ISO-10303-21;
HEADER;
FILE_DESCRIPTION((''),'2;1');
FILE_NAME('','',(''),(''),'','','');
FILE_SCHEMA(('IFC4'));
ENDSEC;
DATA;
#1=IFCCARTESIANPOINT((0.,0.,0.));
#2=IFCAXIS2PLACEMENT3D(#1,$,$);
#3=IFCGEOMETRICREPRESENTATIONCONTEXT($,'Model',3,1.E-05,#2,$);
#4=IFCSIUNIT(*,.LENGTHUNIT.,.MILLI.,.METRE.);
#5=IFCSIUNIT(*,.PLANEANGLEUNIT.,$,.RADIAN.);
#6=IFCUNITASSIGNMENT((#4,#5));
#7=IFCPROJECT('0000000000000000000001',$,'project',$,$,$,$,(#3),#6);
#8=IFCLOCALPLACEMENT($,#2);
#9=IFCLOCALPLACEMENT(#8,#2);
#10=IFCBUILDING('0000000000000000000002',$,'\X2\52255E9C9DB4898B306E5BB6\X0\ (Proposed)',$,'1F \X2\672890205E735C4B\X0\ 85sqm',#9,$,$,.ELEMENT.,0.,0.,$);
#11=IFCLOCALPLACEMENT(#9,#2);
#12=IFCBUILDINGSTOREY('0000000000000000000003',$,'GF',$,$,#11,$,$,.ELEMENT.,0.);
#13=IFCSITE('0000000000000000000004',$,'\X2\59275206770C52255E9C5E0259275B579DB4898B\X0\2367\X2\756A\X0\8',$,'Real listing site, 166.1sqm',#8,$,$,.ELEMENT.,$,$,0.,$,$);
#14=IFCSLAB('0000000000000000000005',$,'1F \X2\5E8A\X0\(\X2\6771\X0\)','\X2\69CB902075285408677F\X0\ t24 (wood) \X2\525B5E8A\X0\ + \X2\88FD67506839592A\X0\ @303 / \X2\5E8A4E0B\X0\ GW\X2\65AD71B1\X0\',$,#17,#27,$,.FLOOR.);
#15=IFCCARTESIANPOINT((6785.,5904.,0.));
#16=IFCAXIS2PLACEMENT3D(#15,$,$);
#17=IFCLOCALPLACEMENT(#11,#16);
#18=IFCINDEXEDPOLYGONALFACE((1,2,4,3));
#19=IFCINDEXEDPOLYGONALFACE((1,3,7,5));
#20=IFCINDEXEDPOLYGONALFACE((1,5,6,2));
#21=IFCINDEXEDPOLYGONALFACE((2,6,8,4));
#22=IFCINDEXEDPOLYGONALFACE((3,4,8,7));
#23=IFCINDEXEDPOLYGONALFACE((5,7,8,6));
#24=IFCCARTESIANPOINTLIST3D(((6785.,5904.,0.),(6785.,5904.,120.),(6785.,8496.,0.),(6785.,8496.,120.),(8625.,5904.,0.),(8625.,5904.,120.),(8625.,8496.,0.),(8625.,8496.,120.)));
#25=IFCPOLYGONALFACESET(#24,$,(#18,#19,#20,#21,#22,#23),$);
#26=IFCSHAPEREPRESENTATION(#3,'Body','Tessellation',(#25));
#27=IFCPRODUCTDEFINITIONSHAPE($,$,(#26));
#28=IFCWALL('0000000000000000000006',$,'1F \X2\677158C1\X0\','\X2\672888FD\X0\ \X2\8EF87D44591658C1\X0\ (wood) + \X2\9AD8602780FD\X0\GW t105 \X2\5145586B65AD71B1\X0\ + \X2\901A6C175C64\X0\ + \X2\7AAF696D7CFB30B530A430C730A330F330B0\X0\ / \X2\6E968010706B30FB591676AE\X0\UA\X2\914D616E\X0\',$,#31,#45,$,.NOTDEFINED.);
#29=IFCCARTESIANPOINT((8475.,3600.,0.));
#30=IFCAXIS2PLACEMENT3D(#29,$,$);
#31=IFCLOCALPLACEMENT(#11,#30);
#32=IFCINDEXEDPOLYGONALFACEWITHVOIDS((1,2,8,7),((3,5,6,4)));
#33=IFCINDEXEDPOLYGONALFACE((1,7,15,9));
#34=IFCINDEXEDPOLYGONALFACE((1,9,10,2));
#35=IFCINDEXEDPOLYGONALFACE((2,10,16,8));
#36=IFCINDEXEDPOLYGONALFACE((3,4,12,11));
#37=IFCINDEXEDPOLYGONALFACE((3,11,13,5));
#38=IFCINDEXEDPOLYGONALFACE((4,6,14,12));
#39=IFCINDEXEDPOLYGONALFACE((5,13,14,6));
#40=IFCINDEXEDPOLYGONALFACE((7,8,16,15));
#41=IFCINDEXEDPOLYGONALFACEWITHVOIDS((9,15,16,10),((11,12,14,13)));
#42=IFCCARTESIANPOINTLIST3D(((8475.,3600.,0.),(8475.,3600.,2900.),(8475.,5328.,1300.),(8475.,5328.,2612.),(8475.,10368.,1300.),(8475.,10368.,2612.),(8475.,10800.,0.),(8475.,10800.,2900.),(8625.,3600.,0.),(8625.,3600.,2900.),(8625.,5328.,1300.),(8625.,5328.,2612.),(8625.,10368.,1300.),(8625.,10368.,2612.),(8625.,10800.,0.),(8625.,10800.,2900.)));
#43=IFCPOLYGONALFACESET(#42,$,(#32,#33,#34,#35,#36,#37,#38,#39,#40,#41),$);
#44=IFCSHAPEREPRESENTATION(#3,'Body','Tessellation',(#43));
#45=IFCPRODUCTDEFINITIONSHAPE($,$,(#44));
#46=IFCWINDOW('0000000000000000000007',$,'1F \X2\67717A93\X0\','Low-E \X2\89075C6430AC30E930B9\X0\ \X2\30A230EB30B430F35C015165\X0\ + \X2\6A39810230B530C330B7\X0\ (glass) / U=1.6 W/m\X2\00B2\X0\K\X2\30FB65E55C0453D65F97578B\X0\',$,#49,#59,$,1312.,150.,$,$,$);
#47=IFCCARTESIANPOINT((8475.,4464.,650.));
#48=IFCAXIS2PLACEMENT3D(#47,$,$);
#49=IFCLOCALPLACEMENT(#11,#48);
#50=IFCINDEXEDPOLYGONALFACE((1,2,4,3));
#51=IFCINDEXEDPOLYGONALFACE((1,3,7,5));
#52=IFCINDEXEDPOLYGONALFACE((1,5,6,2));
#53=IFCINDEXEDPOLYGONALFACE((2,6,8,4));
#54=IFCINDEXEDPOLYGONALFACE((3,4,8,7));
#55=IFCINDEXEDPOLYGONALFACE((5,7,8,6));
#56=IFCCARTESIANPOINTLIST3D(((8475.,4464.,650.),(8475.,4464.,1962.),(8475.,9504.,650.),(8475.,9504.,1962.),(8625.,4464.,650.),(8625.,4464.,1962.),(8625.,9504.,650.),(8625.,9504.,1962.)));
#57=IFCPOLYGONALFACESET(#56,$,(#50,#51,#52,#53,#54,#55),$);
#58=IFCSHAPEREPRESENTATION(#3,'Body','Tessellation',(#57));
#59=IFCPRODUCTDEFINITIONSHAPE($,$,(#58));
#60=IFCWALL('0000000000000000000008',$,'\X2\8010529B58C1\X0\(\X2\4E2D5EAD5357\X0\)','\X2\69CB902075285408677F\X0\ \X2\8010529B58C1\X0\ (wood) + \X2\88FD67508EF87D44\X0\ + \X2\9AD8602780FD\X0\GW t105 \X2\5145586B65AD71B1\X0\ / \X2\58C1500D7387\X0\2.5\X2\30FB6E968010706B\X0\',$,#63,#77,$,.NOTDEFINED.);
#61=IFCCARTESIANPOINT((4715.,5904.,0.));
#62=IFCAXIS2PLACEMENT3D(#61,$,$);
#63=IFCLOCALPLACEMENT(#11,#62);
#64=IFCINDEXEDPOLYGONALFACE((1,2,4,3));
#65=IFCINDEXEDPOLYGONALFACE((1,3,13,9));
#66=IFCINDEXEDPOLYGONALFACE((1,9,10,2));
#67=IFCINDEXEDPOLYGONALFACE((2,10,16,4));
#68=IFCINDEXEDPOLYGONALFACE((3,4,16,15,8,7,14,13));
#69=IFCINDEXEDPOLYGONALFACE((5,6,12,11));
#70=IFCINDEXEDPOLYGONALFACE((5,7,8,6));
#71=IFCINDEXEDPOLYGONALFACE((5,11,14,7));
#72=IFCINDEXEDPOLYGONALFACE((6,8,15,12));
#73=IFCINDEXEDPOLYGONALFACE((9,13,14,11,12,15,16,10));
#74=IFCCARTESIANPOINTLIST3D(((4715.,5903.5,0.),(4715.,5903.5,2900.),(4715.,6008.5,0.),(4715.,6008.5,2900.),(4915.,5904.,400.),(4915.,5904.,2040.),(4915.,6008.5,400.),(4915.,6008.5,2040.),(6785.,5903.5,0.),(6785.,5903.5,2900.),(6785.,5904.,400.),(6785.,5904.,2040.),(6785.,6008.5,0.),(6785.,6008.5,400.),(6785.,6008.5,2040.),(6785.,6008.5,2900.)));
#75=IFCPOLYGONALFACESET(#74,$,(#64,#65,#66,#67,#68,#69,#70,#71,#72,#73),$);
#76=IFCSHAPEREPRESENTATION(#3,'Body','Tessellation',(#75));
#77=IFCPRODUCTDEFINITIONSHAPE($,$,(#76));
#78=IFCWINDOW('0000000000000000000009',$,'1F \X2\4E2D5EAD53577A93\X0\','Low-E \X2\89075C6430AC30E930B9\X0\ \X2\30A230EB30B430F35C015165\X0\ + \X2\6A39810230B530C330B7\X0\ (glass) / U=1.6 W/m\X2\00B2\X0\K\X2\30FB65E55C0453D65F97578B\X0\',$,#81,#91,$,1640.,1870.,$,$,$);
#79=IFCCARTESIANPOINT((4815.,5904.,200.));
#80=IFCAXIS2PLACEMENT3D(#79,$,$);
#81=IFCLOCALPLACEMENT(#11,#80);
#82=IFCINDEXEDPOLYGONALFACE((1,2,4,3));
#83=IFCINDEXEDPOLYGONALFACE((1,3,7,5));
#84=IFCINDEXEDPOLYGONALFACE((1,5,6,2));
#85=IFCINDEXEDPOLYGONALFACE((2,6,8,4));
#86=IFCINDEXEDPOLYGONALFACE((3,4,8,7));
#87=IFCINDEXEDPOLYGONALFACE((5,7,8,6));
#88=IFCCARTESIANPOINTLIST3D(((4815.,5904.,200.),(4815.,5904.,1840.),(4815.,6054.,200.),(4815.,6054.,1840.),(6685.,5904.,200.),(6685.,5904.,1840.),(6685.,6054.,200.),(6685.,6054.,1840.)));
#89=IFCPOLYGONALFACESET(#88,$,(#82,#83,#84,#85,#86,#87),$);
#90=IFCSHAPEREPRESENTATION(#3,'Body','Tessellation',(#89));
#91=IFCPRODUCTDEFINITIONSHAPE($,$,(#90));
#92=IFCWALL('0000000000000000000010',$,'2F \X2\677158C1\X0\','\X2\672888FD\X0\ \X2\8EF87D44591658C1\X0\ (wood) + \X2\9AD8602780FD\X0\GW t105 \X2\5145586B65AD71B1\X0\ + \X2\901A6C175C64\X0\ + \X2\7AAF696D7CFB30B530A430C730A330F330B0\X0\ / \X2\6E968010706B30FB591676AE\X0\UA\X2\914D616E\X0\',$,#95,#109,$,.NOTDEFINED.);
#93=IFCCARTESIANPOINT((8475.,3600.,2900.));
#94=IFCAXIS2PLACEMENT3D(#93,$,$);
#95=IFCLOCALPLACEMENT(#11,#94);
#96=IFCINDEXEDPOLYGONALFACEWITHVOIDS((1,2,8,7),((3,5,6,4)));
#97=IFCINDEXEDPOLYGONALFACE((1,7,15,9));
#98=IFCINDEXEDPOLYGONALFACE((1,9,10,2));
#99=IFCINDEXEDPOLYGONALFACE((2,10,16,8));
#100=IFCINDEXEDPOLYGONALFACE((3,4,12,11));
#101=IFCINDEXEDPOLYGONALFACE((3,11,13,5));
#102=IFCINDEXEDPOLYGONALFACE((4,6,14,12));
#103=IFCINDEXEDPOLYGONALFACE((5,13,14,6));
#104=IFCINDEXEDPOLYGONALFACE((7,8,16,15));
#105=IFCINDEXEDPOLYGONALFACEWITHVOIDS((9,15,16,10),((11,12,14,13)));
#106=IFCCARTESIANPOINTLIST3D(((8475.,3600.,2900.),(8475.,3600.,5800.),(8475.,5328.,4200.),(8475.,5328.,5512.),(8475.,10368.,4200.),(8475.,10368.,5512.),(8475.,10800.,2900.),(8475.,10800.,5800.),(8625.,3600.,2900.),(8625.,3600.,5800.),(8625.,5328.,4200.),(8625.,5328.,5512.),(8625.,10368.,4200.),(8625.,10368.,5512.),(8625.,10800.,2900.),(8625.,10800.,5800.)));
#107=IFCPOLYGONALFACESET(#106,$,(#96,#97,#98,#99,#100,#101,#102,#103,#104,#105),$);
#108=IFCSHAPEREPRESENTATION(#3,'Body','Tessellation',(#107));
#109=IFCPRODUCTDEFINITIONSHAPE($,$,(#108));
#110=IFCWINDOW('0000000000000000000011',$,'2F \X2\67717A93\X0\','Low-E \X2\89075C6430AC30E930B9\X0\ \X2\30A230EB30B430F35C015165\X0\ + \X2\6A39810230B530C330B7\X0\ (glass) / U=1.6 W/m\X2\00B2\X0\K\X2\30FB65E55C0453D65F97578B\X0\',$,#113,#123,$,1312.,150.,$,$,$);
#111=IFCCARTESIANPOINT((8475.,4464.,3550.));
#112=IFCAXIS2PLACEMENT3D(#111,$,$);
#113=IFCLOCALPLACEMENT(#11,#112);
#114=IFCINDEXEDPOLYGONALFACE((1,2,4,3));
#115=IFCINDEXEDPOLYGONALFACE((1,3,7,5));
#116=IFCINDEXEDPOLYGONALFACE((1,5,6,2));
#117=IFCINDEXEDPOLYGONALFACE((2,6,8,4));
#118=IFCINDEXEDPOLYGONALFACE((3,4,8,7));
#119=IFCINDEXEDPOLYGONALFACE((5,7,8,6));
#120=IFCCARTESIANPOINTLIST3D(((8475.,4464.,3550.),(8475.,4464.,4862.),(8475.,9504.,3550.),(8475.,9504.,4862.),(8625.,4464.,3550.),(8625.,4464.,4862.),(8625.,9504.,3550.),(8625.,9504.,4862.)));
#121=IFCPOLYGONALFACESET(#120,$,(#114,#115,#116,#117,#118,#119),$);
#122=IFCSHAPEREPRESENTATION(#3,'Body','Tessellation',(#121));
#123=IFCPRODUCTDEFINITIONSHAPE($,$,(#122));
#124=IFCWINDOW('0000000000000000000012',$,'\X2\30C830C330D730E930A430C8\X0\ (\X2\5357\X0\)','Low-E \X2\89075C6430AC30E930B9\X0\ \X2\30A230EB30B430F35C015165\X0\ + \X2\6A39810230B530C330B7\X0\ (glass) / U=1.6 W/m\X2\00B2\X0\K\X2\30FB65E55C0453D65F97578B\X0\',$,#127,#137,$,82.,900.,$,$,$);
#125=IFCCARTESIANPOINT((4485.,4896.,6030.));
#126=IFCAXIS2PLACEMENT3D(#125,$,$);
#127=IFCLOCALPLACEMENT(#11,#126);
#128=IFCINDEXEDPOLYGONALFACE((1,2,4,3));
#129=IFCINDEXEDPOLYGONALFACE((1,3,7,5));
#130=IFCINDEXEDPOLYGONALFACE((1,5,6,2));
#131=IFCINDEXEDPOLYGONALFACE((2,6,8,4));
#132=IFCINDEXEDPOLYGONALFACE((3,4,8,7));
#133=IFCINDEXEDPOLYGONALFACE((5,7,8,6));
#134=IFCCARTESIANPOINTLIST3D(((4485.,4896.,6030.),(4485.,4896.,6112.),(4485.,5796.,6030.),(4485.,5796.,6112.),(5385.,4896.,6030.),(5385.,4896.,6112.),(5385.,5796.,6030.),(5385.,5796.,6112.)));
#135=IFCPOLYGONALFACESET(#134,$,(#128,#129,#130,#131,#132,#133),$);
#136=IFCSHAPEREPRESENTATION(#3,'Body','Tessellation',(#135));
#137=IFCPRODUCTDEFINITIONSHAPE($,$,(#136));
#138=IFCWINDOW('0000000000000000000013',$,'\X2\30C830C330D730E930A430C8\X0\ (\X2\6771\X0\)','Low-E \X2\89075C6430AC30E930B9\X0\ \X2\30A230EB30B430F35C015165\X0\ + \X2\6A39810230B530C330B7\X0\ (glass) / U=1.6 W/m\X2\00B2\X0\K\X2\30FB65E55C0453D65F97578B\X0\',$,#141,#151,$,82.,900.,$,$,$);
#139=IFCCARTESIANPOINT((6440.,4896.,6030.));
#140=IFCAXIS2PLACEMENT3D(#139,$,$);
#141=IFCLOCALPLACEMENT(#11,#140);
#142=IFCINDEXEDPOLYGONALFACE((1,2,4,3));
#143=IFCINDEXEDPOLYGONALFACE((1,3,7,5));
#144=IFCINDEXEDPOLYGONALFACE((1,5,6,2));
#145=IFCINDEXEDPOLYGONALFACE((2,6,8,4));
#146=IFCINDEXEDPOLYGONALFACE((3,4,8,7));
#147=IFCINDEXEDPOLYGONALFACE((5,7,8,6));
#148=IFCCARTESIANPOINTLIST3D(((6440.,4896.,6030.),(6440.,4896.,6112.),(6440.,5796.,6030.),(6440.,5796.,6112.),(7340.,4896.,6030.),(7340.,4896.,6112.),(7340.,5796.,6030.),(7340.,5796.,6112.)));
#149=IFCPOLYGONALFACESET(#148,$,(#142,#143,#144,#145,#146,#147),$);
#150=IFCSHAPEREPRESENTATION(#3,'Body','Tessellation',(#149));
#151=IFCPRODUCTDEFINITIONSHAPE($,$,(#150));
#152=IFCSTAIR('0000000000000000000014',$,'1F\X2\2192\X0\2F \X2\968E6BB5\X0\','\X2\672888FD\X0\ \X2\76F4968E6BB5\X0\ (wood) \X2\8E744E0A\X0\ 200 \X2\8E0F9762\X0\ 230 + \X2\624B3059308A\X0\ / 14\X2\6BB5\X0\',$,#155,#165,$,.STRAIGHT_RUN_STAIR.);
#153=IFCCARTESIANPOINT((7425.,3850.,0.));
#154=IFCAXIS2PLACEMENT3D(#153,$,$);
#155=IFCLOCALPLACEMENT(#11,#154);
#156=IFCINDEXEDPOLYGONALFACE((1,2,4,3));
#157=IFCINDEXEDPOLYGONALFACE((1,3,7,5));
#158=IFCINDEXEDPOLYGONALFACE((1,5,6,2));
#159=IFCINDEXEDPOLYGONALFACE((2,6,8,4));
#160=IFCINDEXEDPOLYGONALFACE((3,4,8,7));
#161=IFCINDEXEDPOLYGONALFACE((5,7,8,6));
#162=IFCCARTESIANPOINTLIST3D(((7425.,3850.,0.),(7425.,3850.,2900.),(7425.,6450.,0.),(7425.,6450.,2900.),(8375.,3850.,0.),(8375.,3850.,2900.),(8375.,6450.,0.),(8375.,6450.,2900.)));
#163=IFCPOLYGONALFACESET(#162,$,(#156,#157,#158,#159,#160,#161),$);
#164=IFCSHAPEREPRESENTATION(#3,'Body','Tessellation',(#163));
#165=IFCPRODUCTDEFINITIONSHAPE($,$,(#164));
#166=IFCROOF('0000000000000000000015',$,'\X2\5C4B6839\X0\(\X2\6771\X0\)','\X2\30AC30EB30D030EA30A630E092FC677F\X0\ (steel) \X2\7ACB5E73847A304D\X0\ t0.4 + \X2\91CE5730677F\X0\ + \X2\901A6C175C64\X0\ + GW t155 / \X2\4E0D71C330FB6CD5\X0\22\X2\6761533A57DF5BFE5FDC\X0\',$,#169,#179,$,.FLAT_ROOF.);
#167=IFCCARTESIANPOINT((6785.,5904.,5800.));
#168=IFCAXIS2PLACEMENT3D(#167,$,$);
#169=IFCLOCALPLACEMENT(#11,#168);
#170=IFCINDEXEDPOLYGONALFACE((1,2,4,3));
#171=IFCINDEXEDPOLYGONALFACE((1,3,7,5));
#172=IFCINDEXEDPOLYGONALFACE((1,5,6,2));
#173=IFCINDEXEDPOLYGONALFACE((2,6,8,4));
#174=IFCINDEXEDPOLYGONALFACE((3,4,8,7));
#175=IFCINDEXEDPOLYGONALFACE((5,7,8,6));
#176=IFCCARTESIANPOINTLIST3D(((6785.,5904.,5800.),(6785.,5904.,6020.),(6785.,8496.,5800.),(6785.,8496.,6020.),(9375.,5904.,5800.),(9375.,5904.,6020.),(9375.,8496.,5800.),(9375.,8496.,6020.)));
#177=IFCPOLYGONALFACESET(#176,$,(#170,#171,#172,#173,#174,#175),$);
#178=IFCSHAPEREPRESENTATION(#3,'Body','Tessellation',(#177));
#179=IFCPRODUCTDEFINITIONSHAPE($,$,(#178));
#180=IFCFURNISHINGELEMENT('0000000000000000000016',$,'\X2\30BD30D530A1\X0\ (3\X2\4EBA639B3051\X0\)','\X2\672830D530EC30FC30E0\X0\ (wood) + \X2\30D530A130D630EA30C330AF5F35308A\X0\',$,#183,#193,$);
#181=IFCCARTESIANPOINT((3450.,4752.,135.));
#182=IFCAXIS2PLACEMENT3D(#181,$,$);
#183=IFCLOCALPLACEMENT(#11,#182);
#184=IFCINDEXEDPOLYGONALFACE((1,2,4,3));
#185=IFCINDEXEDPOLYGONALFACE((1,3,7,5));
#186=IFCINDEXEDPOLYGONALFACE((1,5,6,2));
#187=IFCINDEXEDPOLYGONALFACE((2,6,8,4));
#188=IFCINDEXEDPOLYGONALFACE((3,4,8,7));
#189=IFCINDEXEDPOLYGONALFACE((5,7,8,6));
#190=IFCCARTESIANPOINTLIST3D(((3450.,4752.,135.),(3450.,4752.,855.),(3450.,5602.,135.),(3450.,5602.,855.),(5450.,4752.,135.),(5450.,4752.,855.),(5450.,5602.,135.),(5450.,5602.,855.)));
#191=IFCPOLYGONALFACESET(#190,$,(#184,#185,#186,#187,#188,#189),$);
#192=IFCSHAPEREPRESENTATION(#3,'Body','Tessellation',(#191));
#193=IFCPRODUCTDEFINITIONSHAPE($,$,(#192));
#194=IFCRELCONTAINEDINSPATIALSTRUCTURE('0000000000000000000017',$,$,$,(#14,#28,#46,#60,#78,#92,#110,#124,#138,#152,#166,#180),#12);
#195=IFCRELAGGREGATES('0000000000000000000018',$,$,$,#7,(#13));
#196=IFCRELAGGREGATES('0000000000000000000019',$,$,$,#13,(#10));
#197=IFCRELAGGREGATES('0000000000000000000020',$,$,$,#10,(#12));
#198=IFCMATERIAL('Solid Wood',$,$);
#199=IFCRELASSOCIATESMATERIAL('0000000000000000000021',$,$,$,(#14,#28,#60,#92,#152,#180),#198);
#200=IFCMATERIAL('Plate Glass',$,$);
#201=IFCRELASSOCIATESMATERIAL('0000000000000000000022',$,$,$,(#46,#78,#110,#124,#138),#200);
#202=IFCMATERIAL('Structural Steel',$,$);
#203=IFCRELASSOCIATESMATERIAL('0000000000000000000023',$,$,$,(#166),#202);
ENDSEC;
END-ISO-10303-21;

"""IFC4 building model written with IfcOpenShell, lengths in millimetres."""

from ifc_helpers import new_model, si_unit, frame, frame_2d, origin, place, context, project, spatial, rectangle, extrude, material, element, fill, save


model = new_model("IFC4")

# Units and contexts
model_context = context("Model", 3, precision=1e-05, world=origin())
ifc_project = project(units=[si_unit("LENGTHUNIT", "METRE", prefix="MILLI"), si_unit("PLANEANGLEUNIT", "RADIAN")], contexts=[model_context])

# Site, building, storey
site_placement = place(None, origin())
site = spatial("IfcSite", under=ifc_project, at=site_placement, Name="大分県別府市大字鶴見2367番8", ObjectType="Real listing site, 166.1sqm", CompositionType="ELEMENT", RefElevation=0.0)
building_placement = place(site_placement, origin())
building = spatial("IfcBuilding", under=site, at=building_placement, Name="別府鶴見の家 (Proposed)", ObjectType="1F 木造平屋 85sqm", CompositionType="ELEMENT", ElevationOfRefHeight=0.0, ElevationOfTerrain=0.0)
storey_placement = place(building_placement, origin())
storey = spatial("IfcBuildingStorey", under=building, at=storey_placement, Name="GF", CompositionType="ELEMENT", Elevation=0.0)

# Slab
ifc_material_1 = material(Name="Solid Wood")
slab_placement = place(storey_placement, frame((6785.0, 5904.0, 0.0)))
element("IfcSlab", 1, at=slab_placement, inside=storey, material=ifc_material_1, Name="1F 床(東)", Description="構造用合板 t24 (wood) 剛床 + 製材根太 @303 / 床下 GW断熱", PredefinedType="FLOOR", context=model_context, shape_type="SweptSolid", body=[
    extrude(rectangle(XDim=1840.0, YDim=2592.0, at=frame_2d((920.0, 1296.0))), frame((6785.0, 5904.0, 0.0)), (0.0, 0.0, 1.0), 120.0),
])

# Walls, openings, windows
wall_1_placement = place(storey_placement, frame((8475.0, 3600.0, 0.0)))
wall_1 = element("IfcWall", 2, at=wall_1_placement, inside=storey, material=ifc_material_1, Name="1F 東壁", Description="木製 軸組外壁 (wood) + 高性能GW t105 充填断熱 + 通気層 + 窯業系サイディング / 準耐火・外皮UA配慮", PredefinedType="NOTDEFINED", context=model_context, shape_type="SweptSolid", body=[
    extrude(rectangle(XDim=150.0, YDim=7200.0, at=frame_2d((75.0, 3600.0))), frame((8475.0, 3600.0, 0.0)), (0.0, 0.0, 1.0), 2900.0),
])
opening_1_placement = place(storey_placement, frame((8475.0, 4464.0, 650.0)))
opening_1 = element("IfcOpeningElement", 3, at=opening_1_placement, cuts=wall_1, PredefinedType="NOTDEFINED", context=model_context, shape_type="SweptSolid", body=[
    extrude(rectangle(XDim=150.0, YDim=5040.0, at=frame_2d((75.0, 2520.0))), frame((8475.0, 4464.0, 650.0)), (0.0, 0.0, 1.0), 1312.0),
])
ifc_material_2 = material(Name="Plate Glass")
window_1_placement = place(storey_placement, frame((8475.0, 4464.0, 650.0)))
window_1 = element("IfcWindow", 4, at=window_1_placement, inside=storey, material=ifc_material_2, Name="1F 東窓", Description="Low-E 複層ガラス アルゴン封入 + 樹脂サッシ (glass) / U=1.6 W/m²K・日射取得型", OverallHeight=1312.0, OverallWidth=150.0, context=model_context, shape_type="SweptSolid", body=[
    extrude(rectangle(XDim=150.0, YDim=5040.0, at=frame_2d((75.0, 2520.0))), frame((8475.0, 4464.0, 650.0)), (0.0, 0.0, 1.0), 1312.0),
])
fill(opening_1, window_1)
wall_2_placement = place(storey_placement, frame((4715.0, 5904.0, 0.0)))
wall_2 = element("IfcWall", 5, at=wall_2_placement, inside=storey, material=ifc_material_1, Name="耐力壁(中庭南)", Description="構造用合板 耐力壁 (wood) + 製材軸組 + 高性能GW t105 充填断熱 / 壁倍率2.5・準耐火", PredefinedType="NOTDEFINED", context=model_context, shape_type="SweptSolid", body=[
    extrude(rectangle(XDim=2070.0, YDim=105.0, at=frame_2d((1035.0, 52.0))), frame((4715.0, 5904.0, 0.0)), (0.0, 0.0, 1.0), 2900.0),
])
opening_2_placement = place(storey_placement, frame((4815.0, 5904.0, 200.0)))
opening_2 = element("IfcOpeningElement", 6, at=opening_2_placement, cuts=wall_2, PredefinedType="NOTDEFINED", context=model_context, shape_type="SweptSolid", body=[
    extrude(rectangle(XDim=1870.0, YDim=150.0, at=frame_2d((935.0, 75.0))), frame((4815.0, 5904.0, 200.0)), (0.0, 0.0, 1.0), 1640.0),
])
window_2_placement = place(storey_placement, frame((4815.0, 5904.0, 200.0)))
window_2 = element("IfcWindow", 7, at=window_2_placement, inside=storey, material=ifc_material_2, Name="1F 中庭南窓", Description="Low-E 複層ガラス アルゴン封入 + 樹脂サッシ (glass) / U=1.6 W/m²K・日射取得型", OverallHeight=1640.0, OverallWidth=1870.0, context=model_context, shape_type="SweptSolid", body=[
    extrude(rectangle(XDim=1870.0, YDim=150.0, at=frame_2d((935.0, 75.0))), frame((4815.0, 5904.0, 200.0)), (0.0, 0.0, 1.0), 1640.0),
])
fill(opening_2, window_2)

# Wall, opening, window
wall_3_placement = place(storey_placement, frame((8475.0, 3600.0, 2900.0)))
wall_3 = element("IfcWall", 8, at=wall_3_placement, inside=storey, material=ifc_material_1, Name="2F 東壁", Description="木製 軸組外壁 (wood) + 高性能GW t105 充填断熱 + 通気層 + 窯業系サイディング / 準耐火・外皮UA配慮", PredefinedType="NOTDEFINED", context=model_context, shape_type="SweptSolid", body=[
    extrude(rectangle(XDim=150.0, YDim=7200.0, at=frame_2d((75.0, 3600.0))), frame((8475.0, 3600.0, 2900.0)), (0.0, 0.0, 1.0), 2900.0),
])
opening_3_placement = place(storey_placement, frame((8475.0, 4464.0, 3550.0)))
opening_3 = element("IfcOpeningElement", 9, at=opening_3_placement, cuts=wall_3, PredefinedType="NOTDEFINED", context=model_context, shape_type="SweptSolid", body=[
    extrude(rectangle(XDim=150.0, YDim=5040.0, at=frame_2d((75.0, 2520.0))), frame((8475.0, 4464.0, 3550.0)), (0.0, 0.0, 1.0), 1312.0),
])
window_3_placement = place(storey_placement, frame((8475.0, 4464.0, 3550.0)))
window_3 = element("IfcWindow", 10, at=window_3_placement, inside=storey, material=ifc_material_2, Name="2F 東窓", Description="Low-E 複層ガラス アルゴン封入 + 樹脂サッシ (glass) / U=1.6 W/m²K・日射取得型", OverallHeight=1312.0, OverallWidth=150.0, context=model_context, shape_type="SweptSolid", body=[
    extrude(rectangle(XDim=150.0, YDim=5040.0, at=frame_2d((75.0, 2520.0))), frame((8475.0, 4464.0, 3550.0)), (0.0, 0.0, 1.0), 1312.0),
])
fill(opening_3, window_3)

# Windows
window_4_placement = place(storey_placement, frame((4485.0, 4896.0, 6030.0)))
element("IfcWindow", 11, at=window_4_placement, inside=storey, material=ifc_material_2, Name="トップライト (南)", Description="Low-E 複層ガラス アルゴン封入 + 樹脂サッシ (glass) / U=1.6 W/m²K・日射取得型", OverallHeight=82.0, OverallWidth=900.0, context=model_context, shape_type="SweptSolid", body=[
    extrude(rectangle(XDim=900.0, YDim=900.0, at=frame_2d((450.0, 450.0))), frame((4485.0, 4896.0, 6030.0)), (0.0, 0.0, 1.0), 82.0),
])
window_5_placement = place(storey_placement, frame((6440.0, 4896.0, 6030.0)))
element("IfcWindow", 12, at=window_5_placement, inside=storey, material=ifc_material_2, Name="トップライト (東)", Description="Low-E 複層ガラス アルゴン封入 + 樹脂サッシ (glass) / U=1.6 W/m²K・日射取得型", OverallHeight=82.0, OverallWidth=900.0, context=model_context, shape_type="SweptSolid", body=[
    extrude(rectangle(XDim=900.0, YDim=900.0, at=frame_2d((450.0, 450.0))), frame((6440.0, 4896.0, 6030.0)), (0.0, 0.0, 1.0), 82.0),
])

# Stair
stair_placement = place(storey_placement, frame((7425.0, 3850.0, 0.0)))
element("IfcStair", 13, at=stair_placement, inside=storey, material=ifc_material_1, Name="1F→2F 階段", Description="木製 直階段 (wood) 蹴上 200 踏面 230 + 手すり / 14段", PredefinedType="STRAIGHT_RUN_STAIR", context=model_context, shape_type="SweptSolid", body=[
    extrude(rectangle(XDim=950.0, YDim=2600.0, at=frame_2d((475.0, 1300.0))), frame((7425.0, 3850.0, 0.0)), (0.0, 0.0, 1.0), 2900.0),
])

# Roof
ifc_material_3 = material(Name="Structural Steel")
roof_placement = place(storey_placement, frame((6785.0, 5904.0, 5800.0)))
element("IfcRoof", 14, at=roof_placement, inside=storey, material=ifc_material_3, Name="屋根(東)", Description="ガルバリウム鋼板 (steel) 立平葺き t0.4 + 野地板 + 通気層 + GW t155 / 不燃・法22条区域対応", PredefinedType="FLAT_ROOF", context=model_context, shape_type="SweptSolid", body=[
    extrude(rectangle(XDim=2590.0, YDim=2592.0, at=frame_2d((1295.0, 1296.0))), frame((6785.0, 5904.0, 5800.0)), (0.0, 0.0, 1.0), 220.0),
])

# Furnishing element
furnishing_1_placement = place(storey_placement, frame((3450.0, 4752.0, 135.0)))
element("IfcFurnishingElement", 15, at=furnishing_1_placement, inside=storey, material=ifc_material_1, Name="ソファ (3人掛け)", Description="木フレーム (wood) + ファブリック張り", context=model_context, shape_type="SweptSolid", body=[
    extrude(rectangle(XDim=2000.0, YDim=850.0, at=frame_2d((1000.0, 425.0))), frame((3450.0, 4752.0, 135.0)), (0.0, 0.0, 1.0), 720.0),
])

save(model, "model.ifc")
